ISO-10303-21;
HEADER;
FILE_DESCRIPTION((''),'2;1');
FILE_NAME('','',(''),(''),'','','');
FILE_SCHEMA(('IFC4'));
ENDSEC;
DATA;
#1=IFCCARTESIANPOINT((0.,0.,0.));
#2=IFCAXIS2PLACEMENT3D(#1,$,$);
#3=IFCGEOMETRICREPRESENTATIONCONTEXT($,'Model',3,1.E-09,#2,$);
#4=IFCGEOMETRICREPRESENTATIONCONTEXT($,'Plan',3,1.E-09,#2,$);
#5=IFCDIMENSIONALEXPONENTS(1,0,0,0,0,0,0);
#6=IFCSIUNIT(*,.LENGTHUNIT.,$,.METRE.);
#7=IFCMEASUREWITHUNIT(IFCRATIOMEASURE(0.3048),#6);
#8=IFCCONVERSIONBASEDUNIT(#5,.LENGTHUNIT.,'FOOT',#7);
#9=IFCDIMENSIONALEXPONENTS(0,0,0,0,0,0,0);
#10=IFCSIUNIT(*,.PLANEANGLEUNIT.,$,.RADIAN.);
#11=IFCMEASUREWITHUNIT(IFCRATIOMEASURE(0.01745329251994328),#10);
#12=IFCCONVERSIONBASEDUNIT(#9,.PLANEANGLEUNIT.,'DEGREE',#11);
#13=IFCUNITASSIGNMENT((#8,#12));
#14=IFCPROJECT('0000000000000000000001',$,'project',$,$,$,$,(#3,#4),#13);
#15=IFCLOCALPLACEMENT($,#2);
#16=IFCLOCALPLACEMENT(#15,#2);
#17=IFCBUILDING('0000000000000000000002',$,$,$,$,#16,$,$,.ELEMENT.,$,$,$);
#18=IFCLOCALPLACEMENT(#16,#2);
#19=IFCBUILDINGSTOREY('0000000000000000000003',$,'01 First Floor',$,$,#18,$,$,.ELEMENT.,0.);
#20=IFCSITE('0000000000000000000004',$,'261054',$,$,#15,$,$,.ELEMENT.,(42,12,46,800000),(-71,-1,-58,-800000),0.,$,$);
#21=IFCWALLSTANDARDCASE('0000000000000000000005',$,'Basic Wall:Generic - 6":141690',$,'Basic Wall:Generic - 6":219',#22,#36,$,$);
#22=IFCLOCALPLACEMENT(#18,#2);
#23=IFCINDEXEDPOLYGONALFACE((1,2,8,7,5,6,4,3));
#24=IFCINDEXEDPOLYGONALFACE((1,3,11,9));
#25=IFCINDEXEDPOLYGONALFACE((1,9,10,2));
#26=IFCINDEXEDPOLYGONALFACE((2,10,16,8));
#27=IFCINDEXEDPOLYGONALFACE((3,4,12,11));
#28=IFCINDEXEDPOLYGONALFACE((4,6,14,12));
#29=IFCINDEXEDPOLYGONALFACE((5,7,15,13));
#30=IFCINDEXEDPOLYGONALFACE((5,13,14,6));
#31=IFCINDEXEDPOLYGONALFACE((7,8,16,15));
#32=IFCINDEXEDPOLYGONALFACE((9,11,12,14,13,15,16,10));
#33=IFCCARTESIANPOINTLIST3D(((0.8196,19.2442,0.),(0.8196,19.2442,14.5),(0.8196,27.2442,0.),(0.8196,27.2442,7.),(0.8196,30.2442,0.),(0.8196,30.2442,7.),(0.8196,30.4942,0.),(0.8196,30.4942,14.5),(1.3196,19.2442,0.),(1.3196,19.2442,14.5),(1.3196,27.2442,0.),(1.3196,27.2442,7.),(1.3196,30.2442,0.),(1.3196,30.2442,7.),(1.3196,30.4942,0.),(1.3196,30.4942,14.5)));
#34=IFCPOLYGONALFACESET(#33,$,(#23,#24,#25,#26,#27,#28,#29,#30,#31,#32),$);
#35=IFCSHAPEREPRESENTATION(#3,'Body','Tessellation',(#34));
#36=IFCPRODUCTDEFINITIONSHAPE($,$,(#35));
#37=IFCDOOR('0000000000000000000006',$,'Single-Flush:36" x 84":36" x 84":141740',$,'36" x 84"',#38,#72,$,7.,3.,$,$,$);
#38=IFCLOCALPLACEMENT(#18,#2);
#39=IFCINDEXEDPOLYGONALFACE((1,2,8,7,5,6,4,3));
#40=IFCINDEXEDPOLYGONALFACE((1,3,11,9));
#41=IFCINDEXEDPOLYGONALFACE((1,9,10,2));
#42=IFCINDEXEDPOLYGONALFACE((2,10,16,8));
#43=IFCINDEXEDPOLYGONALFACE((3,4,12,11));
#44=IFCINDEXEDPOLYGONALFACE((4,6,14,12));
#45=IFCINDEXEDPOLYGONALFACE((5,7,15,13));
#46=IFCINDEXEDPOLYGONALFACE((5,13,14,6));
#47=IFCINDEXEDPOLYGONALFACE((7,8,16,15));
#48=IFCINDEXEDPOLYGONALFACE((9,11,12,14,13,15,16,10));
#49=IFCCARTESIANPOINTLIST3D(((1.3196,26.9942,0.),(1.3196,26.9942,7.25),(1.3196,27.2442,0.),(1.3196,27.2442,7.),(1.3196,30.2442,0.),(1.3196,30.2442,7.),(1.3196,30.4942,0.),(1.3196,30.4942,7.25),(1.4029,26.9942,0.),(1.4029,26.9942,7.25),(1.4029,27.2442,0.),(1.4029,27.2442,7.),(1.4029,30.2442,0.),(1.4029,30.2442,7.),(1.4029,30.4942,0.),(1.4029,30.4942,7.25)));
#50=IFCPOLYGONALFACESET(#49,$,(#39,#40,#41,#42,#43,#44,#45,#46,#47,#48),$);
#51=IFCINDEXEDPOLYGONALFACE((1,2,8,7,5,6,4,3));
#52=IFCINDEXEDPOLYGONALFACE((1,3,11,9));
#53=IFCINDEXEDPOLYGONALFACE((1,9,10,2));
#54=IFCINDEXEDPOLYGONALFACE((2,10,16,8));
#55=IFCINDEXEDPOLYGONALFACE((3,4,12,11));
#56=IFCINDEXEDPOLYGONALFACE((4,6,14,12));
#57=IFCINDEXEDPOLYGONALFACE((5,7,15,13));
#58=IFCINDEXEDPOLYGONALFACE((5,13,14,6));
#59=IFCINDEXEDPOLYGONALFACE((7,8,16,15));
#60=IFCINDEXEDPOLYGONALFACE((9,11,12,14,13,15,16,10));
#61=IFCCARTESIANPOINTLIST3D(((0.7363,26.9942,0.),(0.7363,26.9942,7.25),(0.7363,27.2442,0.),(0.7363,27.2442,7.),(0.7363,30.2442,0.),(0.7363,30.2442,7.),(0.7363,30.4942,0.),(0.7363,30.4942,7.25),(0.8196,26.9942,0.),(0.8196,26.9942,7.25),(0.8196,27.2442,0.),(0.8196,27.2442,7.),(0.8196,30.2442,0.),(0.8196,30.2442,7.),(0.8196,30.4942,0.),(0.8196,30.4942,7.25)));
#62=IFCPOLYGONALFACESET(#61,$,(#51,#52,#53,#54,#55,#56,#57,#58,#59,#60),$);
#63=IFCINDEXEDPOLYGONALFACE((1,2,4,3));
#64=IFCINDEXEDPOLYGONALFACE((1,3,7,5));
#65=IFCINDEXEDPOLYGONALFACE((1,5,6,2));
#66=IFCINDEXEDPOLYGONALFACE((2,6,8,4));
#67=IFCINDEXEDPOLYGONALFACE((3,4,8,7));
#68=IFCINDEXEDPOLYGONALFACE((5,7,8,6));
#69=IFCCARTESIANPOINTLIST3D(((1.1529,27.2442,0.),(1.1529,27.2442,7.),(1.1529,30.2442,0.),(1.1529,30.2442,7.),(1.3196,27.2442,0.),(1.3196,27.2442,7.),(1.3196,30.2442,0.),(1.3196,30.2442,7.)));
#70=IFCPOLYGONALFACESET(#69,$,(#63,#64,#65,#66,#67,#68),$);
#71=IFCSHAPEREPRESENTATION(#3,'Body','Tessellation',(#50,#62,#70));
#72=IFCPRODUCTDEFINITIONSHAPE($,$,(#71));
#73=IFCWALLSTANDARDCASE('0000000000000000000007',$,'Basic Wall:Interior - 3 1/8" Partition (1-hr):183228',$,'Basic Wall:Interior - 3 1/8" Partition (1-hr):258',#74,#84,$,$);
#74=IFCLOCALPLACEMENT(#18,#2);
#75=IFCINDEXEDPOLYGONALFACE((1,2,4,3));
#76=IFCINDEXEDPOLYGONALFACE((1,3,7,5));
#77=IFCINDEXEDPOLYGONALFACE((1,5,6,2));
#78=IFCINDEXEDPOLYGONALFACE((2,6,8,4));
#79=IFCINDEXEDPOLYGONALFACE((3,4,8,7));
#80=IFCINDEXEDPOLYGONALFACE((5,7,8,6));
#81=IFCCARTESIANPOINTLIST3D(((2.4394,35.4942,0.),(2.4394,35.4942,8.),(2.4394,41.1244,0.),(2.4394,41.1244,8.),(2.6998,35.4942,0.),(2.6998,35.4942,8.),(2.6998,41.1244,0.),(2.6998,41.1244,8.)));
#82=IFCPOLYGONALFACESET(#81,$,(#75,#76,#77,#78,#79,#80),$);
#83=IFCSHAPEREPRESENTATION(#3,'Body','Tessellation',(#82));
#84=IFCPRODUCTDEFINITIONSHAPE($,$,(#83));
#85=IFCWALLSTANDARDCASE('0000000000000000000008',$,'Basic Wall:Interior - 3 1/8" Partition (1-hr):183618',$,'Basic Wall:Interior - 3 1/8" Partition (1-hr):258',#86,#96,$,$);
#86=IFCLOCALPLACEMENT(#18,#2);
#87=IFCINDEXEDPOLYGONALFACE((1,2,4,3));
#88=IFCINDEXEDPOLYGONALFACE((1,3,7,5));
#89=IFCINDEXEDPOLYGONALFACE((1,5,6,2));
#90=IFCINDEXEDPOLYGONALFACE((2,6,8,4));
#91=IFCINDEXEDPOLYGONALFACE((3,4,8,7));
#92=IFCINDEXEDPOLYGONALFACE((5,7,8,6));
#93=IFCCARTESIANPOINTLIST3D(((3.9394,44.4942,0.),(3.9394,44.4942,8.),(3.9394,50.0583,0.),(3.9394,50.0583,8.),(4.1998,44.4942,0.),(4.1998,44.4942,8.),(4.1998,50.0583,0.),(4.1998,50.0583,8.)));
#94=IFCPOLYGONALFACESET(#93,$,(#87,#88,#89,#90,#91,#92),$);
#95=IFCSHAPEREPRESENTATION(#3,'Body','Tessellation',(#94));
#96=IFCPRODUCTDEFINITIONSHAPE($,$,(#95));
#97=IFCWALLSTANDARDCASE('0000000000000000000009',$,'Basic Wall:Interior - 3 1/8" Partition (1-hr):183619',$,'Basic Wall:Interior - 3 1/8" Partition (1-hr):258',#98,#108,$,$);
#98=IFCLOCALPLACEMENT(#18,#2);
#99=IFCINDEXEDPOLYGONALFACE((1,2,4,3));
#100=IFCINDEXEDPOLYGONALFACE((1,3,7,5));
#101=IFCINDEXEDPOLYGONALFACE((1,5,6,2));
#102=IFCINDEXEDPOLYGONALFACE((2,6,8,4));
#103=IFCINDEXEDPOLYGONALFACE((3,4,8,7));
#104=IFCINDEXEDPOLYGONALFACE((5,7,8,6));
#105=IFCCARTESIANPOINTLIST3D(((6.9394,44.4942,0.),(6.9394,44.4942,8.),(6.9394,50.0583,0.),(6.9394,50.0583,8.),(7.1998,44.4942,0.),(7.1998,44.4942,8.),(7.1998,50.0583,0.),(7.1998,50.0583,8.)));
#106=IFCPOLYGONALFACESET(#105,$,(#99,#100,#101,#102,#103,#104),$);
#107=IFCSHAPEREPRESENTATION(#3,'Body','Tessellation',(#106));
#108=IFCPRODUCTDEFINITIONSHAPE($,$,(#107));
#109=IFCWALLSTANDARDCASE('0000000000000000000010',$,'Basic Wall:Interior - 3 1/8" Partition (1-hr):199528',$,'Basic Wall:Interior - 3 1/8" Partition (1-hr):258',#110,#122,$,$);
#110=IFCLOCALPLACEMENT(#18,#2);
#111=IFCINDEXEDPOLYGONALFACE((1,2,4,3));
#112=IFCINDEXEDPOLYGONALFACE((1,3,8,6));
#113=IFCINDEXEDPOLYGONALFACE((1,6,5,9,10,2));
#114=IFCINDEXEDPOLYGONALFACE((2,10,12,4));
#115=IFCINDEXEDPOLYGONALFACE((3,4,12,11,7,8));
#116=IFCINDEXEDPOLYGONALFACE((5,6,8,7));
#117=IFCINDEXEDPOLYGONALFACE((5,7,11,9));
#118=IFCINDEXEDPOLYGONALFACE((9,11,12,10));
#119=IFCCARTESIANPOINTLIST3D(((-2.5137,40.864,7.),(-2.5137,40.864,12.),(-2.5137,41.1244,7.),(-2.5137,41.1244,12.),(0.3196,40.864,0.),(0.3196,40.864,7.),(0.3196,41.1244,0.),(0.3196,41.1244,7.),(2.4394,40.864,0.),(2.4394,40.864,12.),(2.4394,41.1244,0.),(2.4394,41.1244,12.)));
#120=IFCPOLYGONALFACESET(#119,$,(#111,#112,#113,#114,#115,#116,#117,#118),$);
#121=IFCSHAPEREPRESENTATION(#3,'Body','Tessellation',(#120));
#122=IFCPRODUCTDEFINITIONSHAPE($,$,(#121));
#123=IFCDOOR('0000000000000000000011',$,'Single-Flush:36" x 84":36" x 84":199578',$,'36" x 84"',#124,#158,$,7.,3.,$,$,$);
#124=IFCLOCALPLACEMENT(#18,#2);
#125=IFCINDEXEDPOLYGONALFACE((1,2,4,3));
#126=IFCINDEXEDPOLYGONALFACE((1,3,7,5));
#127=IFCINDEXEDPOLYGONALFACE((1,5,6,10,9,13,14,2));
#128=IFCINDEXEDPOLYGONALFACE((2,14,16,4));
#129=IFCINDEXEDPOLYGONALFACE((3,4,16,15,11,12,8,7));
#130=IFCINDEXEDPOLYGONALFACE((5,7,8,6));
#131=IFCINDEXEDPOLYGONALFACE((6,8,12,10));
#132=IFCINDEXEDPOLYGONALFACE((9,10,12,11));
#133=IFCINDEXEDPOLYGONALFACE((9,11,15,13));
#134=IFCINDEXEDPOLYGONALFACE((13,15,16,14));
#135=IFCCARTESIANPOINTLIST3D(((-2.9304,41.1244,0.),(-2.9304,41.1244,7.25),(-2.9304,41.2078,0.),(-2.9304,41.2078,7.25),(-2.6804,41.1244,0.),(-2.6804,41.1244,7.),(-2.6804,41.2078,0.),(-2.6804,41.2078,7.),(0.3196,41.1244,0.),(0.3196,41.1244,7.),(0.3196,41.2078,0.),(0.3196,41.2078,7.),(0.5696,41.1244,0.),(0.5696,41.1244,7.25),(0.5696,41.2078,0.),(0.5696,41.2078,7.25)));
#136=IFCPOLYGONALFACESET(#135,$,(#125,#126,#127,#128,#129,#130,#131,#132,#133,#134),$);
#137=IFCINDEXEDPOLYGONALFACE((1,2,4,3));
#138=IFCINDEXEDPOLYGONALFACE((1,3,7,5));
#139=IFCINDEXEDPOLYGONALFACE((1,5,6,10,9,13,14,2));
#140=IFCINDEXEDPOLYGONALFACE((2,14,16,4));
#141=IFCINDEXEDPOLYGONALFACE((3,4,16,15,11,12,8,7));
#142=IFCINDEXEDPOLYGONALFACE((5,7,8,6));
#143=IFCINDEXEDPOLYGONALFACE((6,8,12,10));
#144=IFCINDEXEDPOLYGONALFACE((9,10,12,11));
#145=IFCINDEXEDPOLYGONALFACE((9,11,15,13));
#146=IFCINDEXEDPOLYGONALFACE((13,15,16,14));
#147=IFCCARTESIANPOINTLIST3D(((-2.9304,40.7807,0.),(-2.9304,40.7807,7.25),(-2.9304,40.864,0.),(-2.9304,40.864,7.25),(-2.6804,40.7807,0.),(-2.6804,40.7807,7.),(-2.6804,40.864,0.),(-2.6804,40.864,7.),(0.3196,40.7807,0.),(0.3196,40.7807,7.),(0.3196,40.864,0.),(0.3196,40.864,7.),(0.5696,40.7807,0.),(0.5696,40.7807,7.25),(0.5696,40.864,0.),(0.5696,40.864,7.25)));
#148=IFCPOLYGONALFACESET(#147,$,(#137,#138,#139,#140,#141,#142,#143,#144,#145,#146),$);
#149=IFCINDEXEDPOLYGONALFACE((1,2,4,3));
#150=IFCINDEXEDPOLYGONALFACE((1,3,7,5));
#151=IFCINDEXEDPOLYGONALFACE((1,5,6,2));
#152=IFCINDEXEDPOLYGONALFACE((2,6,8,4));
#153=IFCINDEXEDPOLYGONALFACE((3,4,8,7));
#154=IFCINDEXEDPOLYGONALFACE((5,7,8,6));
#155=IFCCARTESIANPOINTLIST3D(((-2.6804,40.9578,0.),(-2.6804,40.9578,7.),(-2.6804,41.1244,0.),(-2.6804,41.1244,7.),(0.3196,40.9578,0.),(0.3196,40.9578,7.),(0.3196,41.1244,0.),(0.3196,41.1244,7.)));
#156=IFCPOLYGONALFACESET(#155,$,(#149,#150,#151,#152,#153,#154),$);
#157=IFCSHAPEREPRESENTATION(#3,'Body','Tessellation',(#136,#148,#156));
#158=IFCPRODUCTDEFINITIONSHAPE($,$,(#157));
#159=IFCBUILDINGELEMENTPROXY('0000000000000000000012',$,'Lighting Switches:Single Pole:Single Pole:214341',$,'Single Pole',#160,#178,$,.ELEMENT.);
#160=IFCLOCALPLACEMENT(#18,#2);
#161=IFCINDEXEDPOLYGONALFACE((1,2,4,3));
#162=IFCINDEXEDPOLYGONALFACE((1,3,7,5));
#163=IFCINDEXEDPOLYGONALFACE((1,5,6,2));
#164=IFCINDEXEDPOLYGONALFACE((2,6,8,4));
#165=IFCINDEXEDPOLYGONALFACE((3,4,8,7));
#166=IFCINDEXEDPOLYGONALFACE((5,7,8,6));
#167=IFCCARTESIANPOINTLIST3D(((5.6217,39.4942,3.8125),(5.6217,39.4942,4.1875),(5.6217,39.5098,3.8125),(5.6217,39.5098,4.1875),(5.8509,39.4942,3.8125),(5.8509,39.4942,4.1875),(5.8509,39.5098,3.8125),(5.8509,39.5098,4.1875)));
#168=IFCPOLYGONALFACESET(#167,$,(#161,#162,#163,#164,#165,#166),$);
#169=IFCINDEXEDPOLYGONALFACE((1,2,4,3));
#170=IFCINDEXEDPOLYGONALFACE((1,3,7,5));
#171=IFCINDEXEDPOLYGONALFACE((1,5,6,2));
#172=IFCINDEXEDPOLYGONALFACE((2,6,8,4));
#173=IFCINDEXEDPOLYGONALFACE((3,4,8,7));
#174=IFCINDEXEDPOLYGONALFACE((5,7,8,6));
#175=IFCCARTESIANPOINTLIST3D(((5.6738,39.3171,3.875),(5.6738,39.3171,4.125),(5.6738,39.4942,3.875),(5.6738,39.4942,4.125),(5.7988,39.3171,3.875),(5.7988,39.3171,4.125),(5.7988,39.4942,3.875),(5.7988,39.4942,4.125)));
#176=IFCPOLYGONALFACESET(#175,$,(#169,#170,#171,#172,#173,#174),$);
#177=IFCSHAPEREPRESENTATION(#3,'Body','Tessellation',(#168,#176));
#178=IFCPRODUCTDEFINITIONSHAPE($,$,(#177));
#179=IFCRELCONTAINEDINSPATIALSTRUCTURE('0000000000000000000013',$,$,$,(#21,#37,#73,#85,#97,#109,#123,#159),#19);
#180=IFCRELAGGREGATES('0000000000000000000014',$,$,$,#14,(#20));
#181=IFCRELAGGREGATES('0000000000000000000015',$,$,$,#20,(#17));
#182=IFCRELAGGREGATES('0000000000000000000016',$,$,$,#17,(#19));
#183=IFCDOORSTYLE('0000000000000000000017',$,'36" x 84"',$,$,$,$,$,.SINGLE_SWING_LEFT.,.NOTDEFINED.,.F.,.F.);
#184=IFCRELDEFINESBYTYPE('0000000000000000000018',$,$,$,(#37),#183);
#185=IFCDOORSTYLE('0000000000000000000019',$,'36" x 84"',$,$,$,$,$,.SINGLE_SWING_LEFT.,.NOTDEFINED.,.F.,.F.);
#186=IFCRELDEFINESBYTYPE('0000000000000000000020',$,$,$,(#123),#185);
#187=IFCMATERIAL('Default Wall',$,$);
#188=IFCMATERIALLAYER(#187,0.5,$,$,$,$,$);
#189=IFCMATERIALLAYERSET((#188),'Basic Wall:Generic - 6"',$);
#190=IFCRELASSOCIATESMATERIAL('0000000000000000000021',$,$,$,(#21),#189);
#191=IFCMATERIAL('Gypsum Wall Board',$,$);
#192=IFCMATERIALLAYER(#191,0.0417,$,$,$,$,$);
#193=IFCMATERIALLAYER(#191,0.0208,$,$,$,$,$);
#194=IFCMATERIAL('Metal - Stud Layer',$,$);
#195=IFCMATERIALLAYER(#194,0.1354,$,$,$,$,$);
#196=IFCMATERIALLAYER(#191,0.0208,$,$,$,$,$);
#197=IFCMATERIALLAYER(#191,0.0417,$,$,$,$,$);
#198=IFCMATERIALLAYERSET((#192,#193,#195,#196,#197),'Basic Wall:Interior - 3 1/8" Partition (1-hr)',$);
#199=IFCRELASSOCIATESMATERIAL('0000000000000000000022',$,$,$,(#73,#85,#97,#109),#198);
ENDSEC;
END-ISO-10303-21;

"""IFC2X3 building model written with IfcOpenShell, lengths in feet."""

from ifc_helpers import new_model, entity, si_unit, converted_unit, frame, frame_2d, origin, origin_2d_with_axis, place, context, project, spatial, polyline, rectangle, outline, extrude, clip, bounded_halfspace, source, transform, mapped, material, layer, layer_set, layer_usage, type_object, type_shapes, element, fill, save


model = new_model("IFC2X3")

# Units and contexts
model_context = context("Model", 3, precision=1e-09, world=origin())
plan_context = context("Plan", 3, precision=1e-09, world=origin())
ifc_project = project(units=[converted_unit("LENGTHUNIT", "FOOT", entity("IfcRatioMeasure", 0.3048), si_unit("LENGTHUNIT", "METRE"), dimensions=[1, 0, 0, 0, 0, 0, 0]), converted_unit("PLANEANGLEUNIT", "DEGREE", entity("IfcRatioMeasure", 0.01745329251994328), si_unit("PLANEANGLEUNIT", "RADIAN"), dimensions=[0, 0, 0, 0, 0, 0, 0])], contexts=[model_context, plan_context])

# Site, building, storey
site_placement = place(None, origin())
site = spatial("IfcSite", under=ifc_project, at=site_placement, Name="261054", CompositionType="ELEMENT", RefLatitude=(42, 12, 46, 800000), RefLongitude=(-71, -1, -58, -800000), RefElevation=0.0)
building_placement = place(site_placement, origin())
building = spatial("IfcBuilding", under=site, at=building_placement, CompositionType="ELEMENT")
storey_placement = place(building_placement, origin())
storey = spatial("IfcBuildingStorey", under=building, at=storey_placement, Name="01 First Floor", CompositionType="ELEMENT", Elevation=0.0)

# Shared definitions
ifc_material_1 = material(Name="Gypsum Wall Board")
ifc_material_2 = material(Name="Default Wall")
ifc_layer_1 = layer(ifc_material_2, 0.5)
ifc_layer_set_1 = layer_set([ifc_layer_1], Name="Basic Wall:Generic - 6\"")

# Shared definitions
door_style_1 = type_object("IfcDoorStyle", Name="36\" x 84\"", ConstructionType="NOTDEFINED", OperationType="SINGLE_SWING_LEFT", ParameterTakesPrecedence=False, Sizeable=False)
shared_shape_1 = source(origin(), model_context, "Body", "SweptSolid", [
    extrude(outline(polyline([(-1.75, -3.6875), (1.75, -3.6875), (1.75, 3.5625), (1.5, 3.5625), (1.5, -3.4375), (-1.5, -3.4375), (-1.5, 3.5625), (-1.75, 3.5625), (-1.75, -3.6875)])), frame((1.5, 0.5833, 3.5625), z_axis=(0.0, -1.0, 0.0), x_axis=(-1.0, 0.0, 0.0)), (0.0, 0.0, 1.0), 0.0833),
    extrude(outline(polyline([(-3.6875, -1.75), (3.5625, -1.75), (3.5625, -1.5), (-3.4375, -1.5), (-3.4375, 1.5), (3.5625, 1.5), (3.5625, 1.75), (-3.6875, 1.75), (-3.6875, -1.75)])), frame((1.5, 0.0, 3.5625), z_axis=(0.0, -1.0, 0.0), x_axis=(0.0, 0.0, -1.0)), (0.0, 0.0, 1.0), 0.0833),
    extrude(rectangle(XDim=3.0, YDim=0.1667, at=origin_2d_with_axis()), frame((1.5, 0.4167, 0.0)), (0.0, 0.0, 1.0), 7.0),
])
type_shapes(door_style_1, [shared_shape_1])

# Wall, opening, door
ifc_layer_usage_1 = layer_usage(ifc_layer_set_1, "AXIS2", "NEGATIVE", 0.25)
wall_1_placement = place(storey_placement, frame((1.0696, 30.4942, 0.0), z_axis=(0.0, 0.0, 1.0), x_axis=(0.0, -1.0, 0.0)))
wall_1 = element("IfcWallStandardCase", 1, at=wall_1_placement, inside=storey, material=ifc_layer_usage_1, Name="Basic Wall:Generic - 6\":141690", ObjectType="Basic Wall:Generic - 6\":219", context=model_context, shape_type="Clipping", body=[
    clip(extrude(rectangle(XDim=11.25, YDim=0.5, at=frame_2d((5.625, 0.0), x_axis=(-1.0, 0.0))), origin(), (0.0, 0.0, 1.0), 14.5), bounded_halfspace(frame((0.0, -0.25, 14.5), z_axis=(0.0, 0.0, -1.0), x_axis=(0.0, 1.0, 0.0)), True, frame((0.0, -0.25, 14.5)), polyline([(0.0, 0.0), (11.25, 0.0), (11.25, 0.5), (0.0, 0.5), (0.0, 0.0)]))),
])
opening_1_placement = place(wall_1_placement, frame((0.25, -0.25, 0.0)))
opening_1 = element("IfcOpeningElement", 2, at=opening_1_placement, cuts=wall_1, ObjectType="Opening", context=model_context, shape_type="SweptSolid", body=[
    extrude(rectangle(XDim=3.0, YDim=7.0, at=frame_2d((3.5, 1.5), x_axis=(0.0, -1.0))), frame((0.0, 0.0, 0.0), z_axis=(0.0, 1.0, 0.0), x_axis=(0.0, 0.0, 1.0)), (0.0, 0.0, 1.0), 0.5),
])
door_1_placement = place(opening_1_placement, origin())
door_1 = element("IfcDoor", 3, at=door_1_placement, inside=storey, type_object=door_style_1, Name="Single-Flush:36\" x 84\":36\" x 84\":141740", ObjectType="36\" x 84\"", OverallHeight=7.0, OverallWidth=3.0, context=model_context, shape_type="MappedRepresentation", body=[
    mapped(shared_shape_1, transform((0.0, 0.0, 0.0), scale=1.0)),
])
fill(opening_1, door_1)

# Walls
ifc_layer_2 = layer(ifc_material_1, 0.0417)
ifc_layer_3 = layer(ifc_material_1, 0.0208)
ifc_material_3 = material(Name="Metal - Stud Layer")
ifc_layer_4 = layer(ifc_material_3, 0.1354)
ifc_layer_5 = layer(ifc_material_1, 0.0208)
ifc_layer_6 = layer(ifc_material_1, 0.0417)
ifc_layer_set_2 = layer_set([ifc_layer_2, ifc_layer_3, ifc_layer_4, ifc_layer_5, ifc_layer_6], Name="Basic Wall:Interior - 3 1/8\" Partition (1-hr)")
ifc_layer_usage_2 = layer_usage(ifc_layer_set_2, "AXIS2", "NEGATIVE", 0.1302)
wall_2_placement = place(storey_placement, frame((2.5696, 35.4942, 0.0), z_axis=(0.0, 0.0, 1.0), x_axis=(0.0, 1.0, 0.0)))
element("IfcWallStandardCase", 4, at=wall_2_placement, inside=storey, material=ifc_layer_usage_2, Name="Basic Wall:Interior - 3 1/8\" Partition (1-hr):183228", ObjectType="Basic Wall:Interior - 3 1/8\" Partition (1-hr):258", context=model_context, shape_type="SweptSolid", body=[
    extrude(rectangle(XDim=5.6302, YDim=0.2604, at=frame_2d((2.8151, 0.0), x_axis=(-1.0, 0.0))), origin(), (0.0, 0.0, 1.0), 8.0),
])
ifc_layer_usage_3 = layer_usage(ifc_layer_set_2, "AXIS2", "POSITIVE", -0.1302)
wall_3_placement = place(storey_placement, frame((4.0696, 50.0583, 0.0), z_axis=(0.0, 0.0, 1.0), x_axis=(0.0, -1.0, 0.0)))
element("IfcWallStandardCase", 5, at=wall_3_placement, inside=storey, material=ifc_layer_usage_3, Name="Basic Wall:Interior - 3 1/8\" Partition (1-hr):183618", ObjectType="Basic Wall:Interior - 3 1/8\" Partition (1-hr):258", context=model_context, shape_type="SweptSolid", body=[
    extrude(rectangle(XDim=5.564, YDim=0.2604, at=frame_2d((2.782, 0.0), x_axis=(-1.0, 0.0))), origin(), (0.0, 0.0, 1.0), 8.0),
])
ifc_layer_usage_4 = layer_usage(ifc_layer_set_2, "AXIS2", "POSITIVE", -0.1302)
wall_4_placement = place(storey_placement, frame((7.0696, 50.0583, 0.0), z_axis=(0.0, 0.0, 1.0), x_axis=(0.0, -1.0, 0.0)))
element("IfcWallStandardCase", 6, at=wall_4_placement, inside=storey, material=ifc_layer_usage_4, Name="Basic Wall:Interior - 3 1/8\" Partition (1-hr):183619", ObjectType="Basic Wall:Interior - 3 1/8\" Partition (1-hr):258", context=model_context, shape_type="SweptSolid", body=[
    extrude(rectangle(XDim=5.564, YDim=0.2604, at=frame_2d((2.782, 0.0), x_axis=(-1.0, 0.0))), origin(), (0.0, 0.0, 1.0), 8.0),
])

# Wall, opening, door
ifc_layer_usage_5 = layer_usage(ifc_layer_set_2, "AXIS2", "NEGATIVE", 0.1302)
wall_5_placement = place(storey_placement, frame((2.4394, 40.9942, 0.0), z_axis=(0.0, 0.0, 1.0), x_axis=(-1.0, 0.0, 0.0)))
wall_5 = element("IfcWallStandardCase", 7, at=wall_5_placement, inside=storey, material=ifc_layer_usage_5, Name="Basic Wall:Interior - 3 1/8\" Partition (1-hr):199528", ObjectType="Basic Wall:Interior - 3 1/8\" Partition (1-hr):258", context=model_context, shape_type="SweptSolid", body=[
    extrude(rectangle(XDim=4.9531, YDim=0.2604, at=frame_2d((2.4766, 0.0), x_axis=(-1.0, 0.0))), origin(), (0.0, 0.0, 1.0), 12.0),
])
opening_2_placement = place(wall_5_placement, frame((5.1198, 0.1302, 0.0)))
opening_2 = element("IfcOpeningElement", 8, at=opening_2_placement, cuts=wall_5, ObjectType="Opening", context=model_context, shape_type="SweptSolid", body=[
    extrude(rectangle(XDim=3.0, YDim=7.0, at=frame_2d((3.5, 1.5), x_axis=(0.0, -1.0))), frame((0.0, 0.0, 0.0), z_axis=(0.0, -1.0, 0.0), x_axis=(0.0, 0.0, 1.0)), (0.0, 0.0, 1.0), 0.2604),
])
door_style_2 = type_object("IfcDoorStyle", Name="36\" x 84\"", ConstructionType="NOTDEFINED", OperationType="SINGLE_SWING_LEFT", ParameterTakesPrecedence=False, Sizeable=False)
shared_shape_2 = source(origin(), model_context, "Body", "SweptSolid", [
    extrude(outline(polyline([(-1.75, -3.6875), (1.75, -3.6875), (1.75, 3.5625), (1.5, 3.5625), (1.5, -3.4375), (-1.5, -3.4375), (-1.5, 3.5625), (-1.75, 3.5625), (-1.75, -3.6875)])), frame((1.5, 0.3437, 3.5625), z_axis=(0.0, -1.0, 0.0), x_axis=(-1.0, 0.0, 0.0)), (0.0, 0.0, 1.0), 0.0833),
    extrude(outline(polyline([(-3.6875, -1.75), (3.5625, -1.75), (3.5625, -1.5), (-3.4375, -1.5), (-3.4375, 1.5), (3.5625, 1.5), (3.5625, 1.75), (-3.6875, 1.75), (-3.6875, -1.75)])), frame((1.5, 0.0, 3.5625), z_axis=(0.0, -1.0, 0.0), x_axis=(0.0, 0.0, -1.0)), (0.0, 0.0, 1.0), 0.0833),
    extrude(rectangle(XDim=3.0, YDim=0.1667, at=origin_2d_with_axis()), frame((1.5, 0.1771, 0.0)), (0.0, 0.0, 1.0), 7.0),
])
type_shapes(door_style_2, [shared_shape_2])
door_2_placement = place(opening_2_placement, frame((0.0, 0.0, 0.0), z_axis=(0.0, 0.0, 1.0), x_axis=(-1.0, 0.0, 0.0)))
door_2 = element("IfcDoor", 9, at=door_2_placement, inside=storey, type_object=door_style_2, Name="Single-Flush:36\" x 84\":36\" x 84\":199578", ObjectType="36\" x 84\"", OverallHeight=7.0, OverallWidth=3.0, context=model_context, shape_type="MappedRepresentation", body=[
    mapped(shared_shape_2, transform((0.0, 0.0, 0.0), scale=1.0)),
])
fill(opening_2, door_2)

# Building element proxy
shared_shape_3 = source(origin(), model_context, "Body", "SweptSolid", [
    extrude(rectangle(XDim=0.2292, YDim=0.375, at=origin_2d_with_axis()), frame((0.0, 0.0, 0.0), z_axis=(0.0, 0.0, 1.0), x_axis=(-1.0, 0.0, 0.0)), (0.0, 0.0, 1.0), 0.0156),
    extrude(rectangle(XDim=0.125, YDim=0.25, at=origin_2d_with_axis()), frame((0.0, 0.0, -0.1771), z_axis=(0.0, 0.0, 1.0), x_axis=(-1.0, 0.0, 0.0)), (0.0, 0.0, 1.0), 0.1771),
])
for number, where, z_axis, x_axis, name in (
    (10, (5.7363, 39.4942, 4.0), (0.0, 1.0, 0.0), (-1.0, 0.0, 0.0), "Lighting Switches:Single Pole:Single Pole:214341"),
):
    element("IfcBuildingElementProxy", number, at=place(storey_placement, frame(where, z_axis=z_axis, x_axis=x_axis)), inside=storey, Name=name, ObjectType="Single Pole", CompositionType="ELEMENT", context=model_context, shape_type="MappedRepresentation", body=[
        mapped(shared_shape_3, transform((0.0, 0.0, 0.0), scale=1.0)),
    ])

save(model, "model.ifc")
